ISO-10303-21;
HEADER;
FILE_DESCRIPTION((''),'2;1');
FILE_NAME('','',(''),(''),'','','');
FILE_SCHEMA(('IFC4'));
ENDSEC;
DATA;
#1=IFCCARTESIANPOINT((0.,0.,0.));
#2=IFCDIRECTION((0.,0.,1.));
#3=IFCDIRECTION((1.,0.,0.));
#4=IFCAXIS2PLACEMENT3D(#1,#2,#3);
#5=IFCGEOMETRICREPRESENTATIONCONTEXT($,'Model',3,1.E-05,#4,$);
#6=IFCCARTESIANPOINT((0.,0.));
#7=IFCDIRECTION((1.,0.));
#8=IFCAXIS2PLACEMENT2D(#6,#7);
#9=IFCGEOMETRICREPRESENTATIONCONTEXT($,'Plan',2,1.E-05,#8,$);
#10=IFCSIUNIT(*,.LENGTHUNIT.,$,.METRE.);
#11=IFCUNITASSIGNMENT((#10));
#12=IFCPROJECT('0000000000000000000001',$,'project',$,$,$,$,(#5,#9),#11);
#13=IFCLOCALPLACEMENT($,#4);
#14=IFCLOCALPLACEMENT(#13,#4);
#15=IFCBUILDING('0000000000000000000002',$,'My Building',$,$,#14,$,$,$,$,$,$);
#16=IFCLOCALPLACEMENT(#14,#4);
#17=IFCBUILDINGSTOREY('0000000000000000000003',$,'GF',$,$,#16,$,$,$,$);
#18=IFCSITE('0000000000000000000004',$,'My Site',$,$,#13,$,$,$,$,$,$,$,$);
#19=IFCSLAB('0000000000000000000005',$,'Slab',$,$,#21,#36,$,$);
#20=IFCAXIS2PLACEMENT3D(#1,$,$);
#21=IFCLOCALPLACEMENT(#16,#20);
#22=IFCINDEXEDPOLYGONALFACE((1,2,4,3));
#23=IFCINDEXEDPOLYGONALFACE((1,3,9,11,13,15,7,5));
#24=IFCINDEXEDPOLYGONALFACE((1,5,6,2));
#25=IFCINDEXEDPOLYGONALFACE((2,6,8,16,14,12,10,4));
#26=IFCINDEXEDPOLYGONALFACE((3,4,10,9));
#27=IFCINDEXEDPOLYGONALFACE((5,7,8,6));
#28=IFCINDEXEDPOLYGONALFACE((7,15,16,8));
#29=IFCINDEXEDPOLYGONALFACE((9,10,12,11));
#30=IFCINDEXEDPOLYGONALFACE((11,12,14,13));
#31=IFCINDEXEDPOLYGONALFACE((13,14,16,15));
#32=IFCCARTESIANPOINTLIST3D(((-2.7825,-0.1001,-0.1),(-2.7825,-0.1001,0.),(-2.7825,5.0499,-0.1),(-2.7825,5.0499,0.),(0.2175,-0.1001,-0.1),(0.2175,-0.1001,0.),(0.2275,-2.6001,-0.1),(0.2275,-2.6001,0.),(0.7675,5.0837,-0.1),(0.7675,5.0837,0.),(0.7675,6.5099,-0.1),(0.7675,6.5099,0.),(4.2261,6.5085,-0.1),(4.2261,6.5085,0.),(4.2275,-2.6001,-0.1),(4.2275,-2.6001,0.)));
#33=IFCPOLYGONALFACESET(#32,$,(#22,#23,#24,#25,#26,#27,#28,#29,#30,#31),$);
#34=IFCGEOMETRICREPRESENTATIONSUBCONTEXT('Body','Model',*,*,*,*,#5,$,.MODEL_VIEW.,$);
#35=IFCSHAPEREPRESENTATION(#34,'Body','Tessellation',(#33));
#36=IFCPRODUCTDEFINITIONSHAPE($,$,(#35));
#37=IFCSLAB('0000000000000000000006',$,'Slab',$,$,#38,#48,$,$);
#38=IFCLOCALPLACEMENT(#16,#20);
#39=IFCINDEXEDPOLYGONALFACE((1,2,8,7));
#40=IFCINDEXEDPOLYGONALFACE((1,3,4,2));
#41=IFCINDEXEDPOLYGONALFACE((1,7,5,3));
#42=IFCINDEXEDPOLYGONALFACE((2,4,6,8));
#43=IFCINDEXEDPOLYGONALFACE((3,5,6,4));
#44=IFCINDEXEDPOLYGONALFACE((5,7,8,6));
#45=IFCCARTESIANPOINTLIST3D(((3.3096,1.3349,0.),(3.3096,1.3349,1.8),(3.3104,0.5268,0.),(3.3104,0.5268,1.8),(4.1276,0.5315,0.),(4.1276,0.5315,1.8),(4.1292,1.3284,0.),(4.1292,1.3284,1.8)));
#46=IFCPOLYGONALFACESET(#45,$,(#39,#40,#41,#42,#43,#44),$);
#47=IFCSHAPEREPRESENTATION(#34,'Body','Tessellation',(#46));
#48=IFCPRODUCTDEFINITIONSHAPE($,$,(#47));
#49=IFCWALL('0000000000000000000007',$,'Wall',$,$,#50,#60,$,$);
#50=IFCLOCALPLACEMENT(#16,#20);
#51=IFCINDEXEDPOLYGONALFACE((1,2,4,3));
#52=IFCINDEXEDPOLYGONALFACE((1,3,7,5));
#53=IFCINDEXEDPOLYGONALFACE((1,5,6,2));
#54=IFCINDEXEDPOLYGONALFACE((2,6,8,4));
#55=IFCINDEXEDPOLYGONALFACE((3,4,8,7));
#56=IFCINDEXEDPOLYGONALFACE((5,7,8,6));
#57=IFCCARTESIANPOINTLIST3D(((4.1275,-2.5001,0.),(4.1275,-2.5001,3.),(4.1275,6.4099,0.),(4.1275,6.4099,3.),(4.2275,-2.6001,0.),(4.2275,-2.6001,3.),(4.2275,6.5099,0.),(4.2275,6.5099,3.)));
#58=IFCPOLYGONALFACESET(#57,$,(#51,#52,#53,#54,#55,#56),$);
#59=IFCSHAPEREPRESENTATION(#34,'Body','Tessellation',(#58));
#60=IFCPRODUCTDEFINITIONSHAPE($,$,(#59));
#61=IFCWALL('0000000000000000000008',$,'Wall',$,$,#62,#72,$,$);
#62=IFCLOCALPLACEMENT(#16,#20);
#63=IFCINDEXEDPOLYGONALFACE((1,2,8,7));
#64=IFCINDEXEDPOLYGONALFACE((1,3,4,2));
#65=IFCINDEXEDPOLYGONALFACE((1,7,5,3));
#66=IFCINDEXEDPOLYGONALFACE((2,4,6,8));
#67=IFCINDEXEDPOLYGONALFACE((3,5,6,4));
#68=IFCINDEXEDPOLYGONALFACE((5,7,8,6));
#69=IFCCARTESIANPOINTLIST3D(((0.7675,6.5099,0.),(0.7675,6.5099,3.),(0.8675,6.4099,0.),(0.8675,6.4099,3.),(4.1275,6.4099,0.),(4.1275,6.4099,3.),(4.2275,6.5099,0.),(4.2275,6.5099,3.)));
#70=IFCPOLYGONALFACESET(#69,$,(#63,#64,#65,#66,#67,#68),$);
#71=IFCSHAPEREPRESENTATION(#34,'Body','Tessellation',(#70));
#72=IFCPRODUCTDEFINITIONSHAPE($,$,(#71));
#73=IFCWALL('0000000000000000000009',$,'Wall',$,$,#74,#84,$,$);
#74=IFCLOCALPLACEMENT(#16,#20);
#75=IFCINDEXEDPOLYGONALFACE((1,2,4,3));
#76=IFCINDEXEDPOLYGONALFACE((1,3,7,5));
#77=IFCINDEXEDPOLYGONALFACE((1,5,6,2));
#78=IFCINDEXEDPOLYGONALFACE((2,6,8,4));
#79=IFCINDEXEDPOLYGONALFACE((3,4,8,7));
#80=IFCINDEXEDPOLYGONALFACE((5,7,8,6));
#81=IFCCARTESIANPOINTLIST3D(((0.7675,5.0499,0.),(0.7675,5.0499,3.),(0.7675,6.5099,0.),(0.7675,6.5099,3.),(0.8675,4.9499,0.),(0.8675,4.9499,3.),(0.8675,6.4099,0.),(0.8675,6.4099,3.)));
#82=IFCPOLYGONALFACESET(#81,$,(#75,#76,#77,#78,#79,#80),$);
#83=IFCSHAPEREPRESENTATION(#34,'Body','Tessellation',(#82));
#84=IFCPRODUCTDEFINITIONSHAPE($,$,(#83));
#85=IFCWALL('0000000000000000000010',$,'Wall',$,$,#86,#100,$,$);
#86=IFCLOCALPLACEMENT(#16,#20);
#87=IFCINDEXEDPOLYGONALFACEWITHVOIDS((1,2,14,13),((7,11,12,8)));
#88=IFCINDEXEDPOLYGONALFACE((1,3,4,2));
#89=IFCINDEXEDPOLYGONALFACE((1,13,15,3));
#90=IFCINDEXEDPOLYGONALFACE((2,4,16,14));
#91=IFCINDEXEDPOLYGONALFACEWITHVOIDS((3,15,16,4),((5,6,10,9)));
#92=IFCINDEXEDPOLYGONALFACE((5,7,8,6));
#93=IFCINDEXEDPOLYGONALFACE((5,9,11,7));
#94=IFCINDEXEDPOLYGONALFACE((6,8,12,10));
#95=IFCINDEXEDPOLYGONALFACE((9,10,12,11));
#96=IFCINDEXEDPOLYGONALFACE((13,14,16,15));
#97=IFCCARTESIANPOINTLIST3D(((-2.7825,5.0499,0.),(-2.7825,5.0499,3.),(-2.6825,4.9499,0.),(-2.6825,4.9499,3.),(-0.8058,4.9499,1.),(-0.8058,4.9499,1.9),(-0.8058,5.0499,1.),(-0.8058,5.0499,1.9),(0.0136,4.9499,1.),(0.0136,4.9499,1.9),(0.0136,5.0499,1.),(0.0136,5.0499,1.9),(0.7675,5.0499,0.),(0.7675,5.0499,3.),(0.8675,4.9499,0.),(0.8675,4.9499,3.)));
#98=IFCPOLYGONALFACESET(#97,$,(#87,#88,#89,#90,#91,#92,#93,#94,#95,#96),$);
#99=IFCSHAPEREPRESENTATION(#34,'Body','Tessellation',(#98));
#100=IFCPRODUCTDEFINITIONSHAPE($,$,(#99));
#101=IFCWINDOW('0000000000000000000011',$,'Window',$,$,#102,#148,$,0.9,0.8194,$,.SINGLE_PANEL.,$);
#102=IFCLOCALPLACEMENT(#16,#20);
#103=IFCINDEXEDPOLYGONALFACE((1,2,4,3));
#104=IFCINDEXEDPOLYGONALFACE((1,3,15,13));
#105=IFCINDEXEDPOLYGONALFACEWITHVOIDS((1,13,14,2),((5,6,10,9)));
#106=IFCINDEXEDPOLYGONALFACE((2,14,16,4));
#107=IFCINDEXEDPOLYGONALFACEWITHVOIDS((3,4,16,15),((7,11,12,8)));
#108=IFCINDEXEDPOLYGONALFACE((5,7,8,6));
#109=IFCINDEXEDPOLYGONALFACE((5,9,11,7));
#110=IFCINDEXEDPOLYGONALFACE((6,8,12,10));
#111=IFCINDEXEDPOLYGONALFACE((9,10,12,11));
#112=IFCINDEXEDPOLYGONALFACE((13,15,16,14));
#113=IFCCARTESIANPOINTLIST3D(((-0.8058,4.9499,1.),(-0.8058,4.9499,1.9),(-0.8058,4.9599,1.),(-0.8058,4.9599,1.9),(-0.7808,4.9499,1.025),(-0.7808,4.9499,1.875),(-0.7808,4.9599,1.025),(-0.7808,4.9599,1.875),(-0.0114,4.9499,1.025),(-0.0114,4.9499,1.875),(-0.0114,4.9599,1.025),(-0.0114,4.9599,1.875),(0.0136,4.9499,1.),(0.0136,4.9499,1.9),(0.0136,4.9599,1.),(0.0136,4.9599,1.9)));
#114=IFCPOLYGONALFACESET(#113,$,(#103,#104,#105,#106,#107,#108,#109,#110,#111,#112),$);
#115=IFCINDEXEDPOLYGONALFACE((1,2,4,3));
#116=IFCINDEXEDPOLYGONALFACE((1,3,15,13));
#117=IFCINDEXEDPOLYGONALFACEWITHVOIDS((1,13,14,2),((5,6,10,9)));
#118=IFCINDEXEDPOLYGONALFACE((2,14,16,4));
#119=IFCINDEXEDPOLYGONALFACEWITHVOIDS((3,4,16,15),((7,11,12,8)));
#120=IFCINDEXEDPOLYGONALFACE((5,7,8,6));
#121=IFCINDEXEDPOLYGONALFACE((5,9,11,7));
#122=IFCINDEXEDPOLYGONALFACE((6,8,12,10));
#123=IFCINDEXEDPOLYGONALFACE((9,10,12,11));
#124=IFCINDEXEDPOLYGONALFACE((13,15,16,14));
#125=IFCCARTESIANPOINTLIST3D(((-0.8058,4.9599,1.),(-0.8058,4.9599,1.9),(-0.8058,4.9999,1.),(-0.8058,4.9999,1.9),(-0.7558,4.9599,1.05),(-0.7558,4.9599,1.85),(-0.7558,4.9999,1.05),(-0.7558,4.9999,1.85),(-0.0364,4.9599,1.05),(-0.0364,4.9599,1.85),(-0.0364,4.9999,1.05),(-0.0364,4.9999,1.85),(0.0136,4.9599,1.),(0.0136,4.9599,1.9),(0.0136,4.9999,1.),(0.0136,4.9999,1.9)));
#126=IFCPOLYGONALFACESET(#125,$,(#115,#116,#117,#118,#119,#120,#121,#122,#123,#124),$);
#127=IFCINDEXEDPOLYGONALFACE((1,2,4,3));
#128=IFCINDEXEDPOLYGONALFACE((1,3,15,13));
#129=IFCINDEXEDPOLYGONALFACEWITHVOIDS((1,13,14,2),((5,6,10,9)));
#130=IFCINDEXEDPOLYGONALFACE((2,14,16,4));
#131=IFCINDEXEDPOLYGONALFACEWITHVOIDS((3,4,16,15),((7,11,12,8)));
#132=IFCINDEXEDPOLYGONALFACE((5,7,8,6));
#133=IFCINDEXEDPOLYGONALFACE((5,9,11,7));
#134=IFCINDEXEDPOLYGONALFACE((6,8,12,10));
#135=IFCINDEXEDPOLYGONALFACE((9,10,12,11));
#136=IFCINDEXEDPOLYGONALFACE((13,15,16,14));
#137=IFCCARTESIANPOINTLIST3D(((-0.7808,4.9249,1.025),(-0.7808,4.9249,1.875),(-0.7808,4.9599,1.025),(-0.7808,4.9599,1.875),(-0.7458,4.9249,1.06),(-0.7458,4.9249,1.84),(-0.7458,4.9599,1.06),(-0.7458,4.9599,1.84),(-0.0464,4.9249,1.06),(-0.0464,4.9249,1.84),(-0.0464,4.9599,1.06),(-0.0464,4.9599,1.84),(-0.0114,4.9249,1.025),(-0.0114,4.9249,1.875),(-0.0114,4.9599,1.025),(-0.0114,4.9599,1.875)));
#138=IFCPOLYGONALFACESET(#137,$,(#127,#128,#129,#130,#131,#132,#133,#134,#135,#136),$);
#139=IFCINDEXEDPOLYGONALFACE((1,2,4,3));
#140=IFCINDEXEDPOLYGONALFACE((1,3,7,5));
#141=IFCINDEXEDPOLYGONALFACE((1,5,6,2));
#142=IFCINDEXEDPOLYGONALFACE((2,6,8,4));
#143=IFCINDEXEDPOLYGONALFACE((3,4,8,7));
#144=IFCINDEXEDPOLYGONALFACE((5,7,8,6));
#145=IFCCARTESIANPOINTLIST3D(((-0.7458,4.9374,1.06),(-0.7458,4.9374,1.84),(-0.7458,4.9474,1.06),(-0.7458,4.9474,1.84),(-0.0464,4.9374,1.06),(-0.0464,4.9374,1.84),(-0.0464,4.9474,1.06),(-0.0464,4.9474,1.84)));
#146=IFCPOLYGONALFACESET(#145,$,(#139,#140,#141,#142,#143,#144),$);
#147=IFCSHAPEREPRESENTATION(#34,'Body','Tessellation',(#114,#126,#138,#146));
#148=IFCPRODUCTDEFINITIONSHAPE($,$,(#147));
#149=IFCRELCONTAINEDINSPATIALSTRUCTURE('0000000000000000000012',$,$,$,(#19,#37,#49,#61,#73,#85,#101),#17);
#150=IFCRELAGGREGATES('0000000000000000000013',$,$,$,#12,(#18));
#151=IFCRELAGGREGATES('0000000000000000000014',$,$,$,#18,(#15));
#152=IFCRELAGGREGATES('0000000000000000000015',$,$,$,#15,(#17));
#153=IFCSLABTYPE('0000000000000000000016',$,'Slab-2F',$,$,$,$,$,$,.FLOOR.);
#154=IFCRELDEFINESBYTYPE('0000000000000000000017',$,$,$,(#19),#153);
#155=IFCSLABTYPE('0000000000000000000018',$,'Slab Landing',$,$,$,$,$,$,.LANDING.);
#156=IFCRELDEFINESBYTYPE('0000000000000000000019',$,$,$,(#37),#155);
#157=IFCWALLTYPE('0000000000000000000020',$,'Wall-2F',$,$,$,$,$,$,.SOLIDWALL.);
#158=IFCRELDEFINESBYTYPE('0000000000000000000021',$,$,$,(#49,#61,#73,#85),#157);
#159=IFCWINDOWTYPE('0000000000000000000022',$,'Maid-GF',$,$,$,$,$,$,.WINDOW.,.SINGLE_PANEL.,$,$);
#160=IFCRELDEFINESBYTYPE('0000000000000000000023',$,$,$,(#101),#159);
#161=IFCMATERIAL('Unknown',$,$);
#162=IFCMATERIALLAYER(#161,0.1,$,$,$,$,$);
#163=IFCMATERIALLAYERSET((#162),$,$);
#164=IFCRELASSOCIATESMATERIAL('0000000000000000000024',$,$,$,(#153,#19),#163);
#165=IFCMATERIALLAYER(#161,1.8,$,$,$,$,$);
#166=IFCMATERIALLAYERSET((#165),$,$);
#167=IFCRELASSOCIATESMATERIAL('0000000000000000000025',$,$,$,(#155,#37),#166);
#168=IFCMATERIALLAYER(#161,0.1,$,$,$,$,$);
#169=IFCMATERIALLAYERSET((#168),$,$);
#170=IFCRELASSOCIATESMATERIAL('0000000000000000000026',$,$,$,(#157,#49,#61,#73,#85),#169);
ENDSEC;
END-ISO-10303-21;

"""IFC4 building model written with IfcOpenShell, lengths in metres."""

from ifc_helpers import new_model, entity, si_unit, frame, origin_with_axes, origin_2d_with_axis, place, context, subcontext, project, spatial, line, indexed_curve, outline, extrude, shape, source, transform, mapped, material, layer, layer_set, layer_usage, type_object, type_shapes, element, fill, save


model = new_model("IFC4")

# Units and contexts
model_context = context("Model", 3, precision=1e-05, world=origin_with_axes())
plan_context = context("Plan", 2, precision=1e-05, world=origin_2d_with_axis())
body_context_1 = subcontext(model_context, "Body", "Model", "MODEL_VIEW")
body_context_2 = subcontext(plan_context, "Body", "Plan", "PLAN_VIEW")
ifc_project = project(units=[si_unit("LENGTHUNIT", "METRE")], contexts=[model_context, plan_context])

# Site, building, storey
site_placement = place(None, origin_with_axes())
site = spatial("IfcSite", under=ifc_project, at=site_placement, Name="My Site")
building_placement = place(site_placement, origin_with_axes())
building = spatial("IfcBuilding", under=site, at=building_placement, Name="My Building")
storey_placement = place(building_placement, origin_with_axes())
storey = spatial("IfcBuildingStorey", under=building, at=storey_placement, Name="GF")

# Slabs
ifc_material_1 = material(Name="Unknown")
ifc_layer_1 = layer(ifc_material_1, 0.1)
ifc_layer_set_1 = layer_set([ifc_layer_1])
ifc_layer_usage_1 = layer_usage(ifc_layer_set_1, "AXIS3", "POSITIVE", -0.1)
slab_type_1 = type_object("IfcSlabType", Name="Slab-2F", PredefinedType="FLOOR", material=ifc_layer_set_1)
slab_1_placement = place(storey_placement, frame((4.2275, -2.6001, 0.0), z_axis=(0.0, 0.0, 1.0), x_axis=(1.0, 0.0, 0.0)))
element("IfcSlab", 1, at=slab_1_placement, inside=storey, type_object=slab_type_1, material=ifc_layer_usage_1, Name="Slab", context=body_context_1, shape_type="SweptSolid", body=[
    extrude(outline(indexed_curve([(0.0, 0.0), (-0.0014, 9.1086), (-3.46, 9.11), (-3.46, 7.6838), (-7.01, 7.65), (-7.01, 2.5), (-4.01, 2.5), (-4.0, 0.0), (0.0, 0.0)])), frame((0.0, 0.0, -0.1), z_axis=(0.0, 0.0, 1.0), x_axis=(1.0, 0.0, 0.0)), (0.0, 0.0, 1.0), 0.1),
])
ifc_layer_2 = layer(ifc_material_1, 1.8)
ifc_layer_set_2 = layer_set([ifc_layer_2])
ifc_layer_usage_2 = layer_usage(ifc_layer_set_2, "AXIS3", "POSITIVE", -0.1)
slab_type_2 = type_object("IfcSlabType", Name="Slab Landing", PredefinedType="LANDING", material=ifc_layer_set_2)
slab_2_placement = place(storey_placement, frame((3.3096, 1.3349, 0.1), z_axis=(0.0, 0.0, 1.0), x_axis=(1.0, 0.0, 0.0)))
element("IfcSlab", 2, at=slab_2_placement, inside=storey, type_object=slab_type_2, material=ifc_layer_usage_2, Name="Slab", context=body_context_1, shape_type="SweptSolid", body=[
    extrude(outline(indexed_curve([(0.0, 0.0), (0.0008, -0.8081), (0.818, -0.8034), (0.8196, -0.0065), (-0.0002, 0.0), (0.0, 0.0)])), frame((0.0, 0.0, -0.1), z_axis=(0.0, 0.0, 1.0), x_axis=(1.0, 0.0, 0.0)), (0.0, 0.0, 1.0), 1.8),
])

# Shared definitions
ifc_layer_3 = layer(ifc_material_1, 0.1)
ifc_layer_set_3 = layer_set([ifc_layer_3])
wall_type = type_object("IfcWallType", Name="Wall-2F", PredefinedType="SOLIDWALL", material=ifc_layer_set_3)

# Walls
ifc_layer_usage_3 = layer_usage(ifc_layer_set_3, "AXIS2", "POSITIVE", 0.0)
wall_1_placement = place(storey_placement, frame((4.2275, -2.6001, 0.0), z_axis=(0.0, 0.0, 1.0), x_axis=(0.0, 1.0, 0.0)))
element("IfcWall", 3, at=wall_1_placement, inside=storey, type_object=wall_type, material=ifc_layer_usage_3, Name="Wall", context=body_context_1, shape_type="SweptSolid", body=[
    extrude(outline(indexed_curve([(0.0, 0.0), (0.1, 0.1), (9.01, 0.1), (9.11, 0.0)], segments=[line(1, 2, 3, 4, 1)])), origin_with_axes(), (0.0, 0.0, 1.0), 3.0),
])
ifc_layer_usage_4 = layer_usage(ifc_layer_set_3, "AXIS2", "POSITIVE", 0.0)
wall_2_placement = place(storey_placement, frame((4.2275, 6.5099, 0.0), z_axis=(0.0, 0.0, 1.0), x_axis=(-1.0, 0.0, 0.0)))
element("IfcWall", 4, at=wall_2_placement, inside=storey, type_object=wall_type, material=ifc_layer_usage_4, Name="Wall", context=body_context_1, shape_type="SweptSolid", body=[
    extrude(outline(indexed_curve([(0.0, 0.0), (0.1, 0.1), (3.36, 0.1), (3.46, 0.0)], segments=[line(1, 2, 3, 4, 1)])), origin_with_axes(), (0.0, 0.0, 1.0), 3.0),
])
ifc_layer_usage_5 = layer_usage(ifc_layer_set_3, "AXIS2", "POSITIVE", 0.0)
wall_3_placement = place(storey_placement, frame((0.7675, 6.5099, 0.0), z_axis=(0.0, 0.0, 1.0), x_axis=(0.0, -1.0, 0.0)))
element("IfcWall", 5, at=wall_3_placement, inside=storey, type_object=wall_type, material=ifc_layer_usage_5, Name="Wall", context=body_context_1, shape_type="SweptSolid", body=[
    extrude(outline(indexed_curve([(0.0, 0.0), (0.1, 0.1), (1.56, 0.1), (1.46, 0.0)], segments=[line(1, 2, 3, 4, 1)])), origin_with_axes(), (0.0, 0.0, 1.0), 3.0),
])

# Wall, opening, window
ifc_layer_usage_6 = layer_usage(ifc_layer_set_3, "AXIS2", "POSITIVE", 0.0)
wall_4_placement = place(storey_placement, frame((0.7675, 5.0499, 0.0), z_axis=(0.0, 0.0, 1.0), x_axis=(-1.0, 0.0, 0.0)))
wall_4 = element("IfcWall", 6, at=wall_4_placement, inside=storey, type_object=wall_type, material=ifc_layer_usage_6, Name="Wall", context=body_context_1, shape_type="SweptSolid", body=[
    extrude(outline(indexed_curve([(0.0, 0.0), (-0.1, 0.1), (3.45, 0.1), (3.55, 0.0)], segments=[line(1, 2, 3, 4, 1)])), origin_with_axes(), (0.0, 0.0, 1.0), 3.0),
])
shared_shape_1 = source(origin_with_axes(), body_context_1, "Body", "SweptSolid", [
    extrude(outline(indexed_curve([(0.0, 0.0), (0.8194, 0.0), (0.8194, 0.9), (0.0, 0.9)], segments=[line(1, 2, 3, 4, 1)])), frame((0.0, -0.6, 0.0), z_axis=(0.0, -1.0, 0.0), x_axis=(1.0, 0.0, 0.0)), (0.0, 0.0, -1.0), 1.2),
])
opening_1_placement = place(wall_4_placement, frame((0.7539, 0.0, 1.0), z_axis=(0.0, 0.0, 1.0), x_axis=(1.0, 0.0, 0.0)))
opening_1 = element("IfcOpeningElement", 7, at=opening_1_placement, cuts=wall_4, PredefinedType="OPENING", context=body_context_1, shape_type="MappedRepresentation", body=[
    mapped(shared_shape_1, transform((0.0, 0.0, 0.0), x_axis=(1.0, 0.0, 0.0), y_axis=(0.0, 1.0, 0.0), z_axis=(0.0, 0.0, 1.0), scale=1.0)),
])
window_type_1 = type_object("IfcWindowType", Name="Maid-GF", PartitioningType="SINGLE_PANEL", PredefinedType="WINDOW")
shared_shape_2 = source(origin_with_axes(), body_context_1, "Body", "SweptSolid", [
    extrude(outline(indexed_curve([(0.0, 0.0), (0.8194, 0.0), (0.8194, 0.9), (0.0, 0.9)], segments=[line(1, 2, 3, 4, 1)]), holes=[indexed_curve([(0.025, 0.025), (0.7944, 0.025), (0.7944, 0.875), (0.025, 0.875)], segments=[line(1, 2, 3, 4, 1)])]), frame((0.0, 0.09, 0.0), z_axis=(0.0, -1.0, 0.0), x_axis=(1.0, 0.0, 0.0)), (0.0, 0.0, -1.0), 0.01),
    extrude(outline(indexed_curve([(0.0, 0.0), (0.8194, 0.0), (0.8194, 0.9), (0.0, 0.9)], segments=[line(1, 2, 3, 4, 1)]), holes=[indexed_curve([(0.05, 0.05), (0.7694, 0.05), (0.7694, 0.85), (0.05, 0.85)], segments=[line(1, 2, 3, 4, 1)])]), frame((0.0, 0.05, 0.0), z_axis=(0.0, -1.0, 0.0), x_axis=(1.0, 0.0, 0.0)), (0.0, 0.0, -1.0), 0.04),
    extrude(outline(indexed_curve([(0.0, 0.0), (0.7694, 0.0), (0.7694, 0.85), (0.0, 0.85)], segments=[line(1, 2, 3, 4, 1)]), holes=[indexed_curve([(0.035, 0.035), (0.7344, 0.035), (0.7344, 0.815), (0.035, 0.815)], segments=[line(1, 2, 3, 4, 1)])]), frame((0.025, 0.09, 0.025), z_axis=(0.0, -1.0, 0.0), x_axis=(1.0, 0.0, 0.0)), (0.0, 0.0, -1.0), 0.035),
    extrude(outline(indexed_curve([(0.035, 0.035), (0.7344, 0.035), (0.7344, 0.815), (0.035, 0.815)], segments=[line(1, 2, 3, 4, 1)])), frame((0.025, 0.1025, 0.025), z_axis=(0.0, -1.0, 0.0), x_axis=(1.0, 0.0, 0.0)), (0.0, 0.0, -1.0), 0.01),
])
shared_shape_3 = source(origin_with_axes(), body_context_2, "Body", "Curve2D", [
    entity("IfcIndexedPolyCurve", entity("IfcCartesianPointList2D", [[0.05, 0.05], [0.7694, 0.05]])),
    entity("IfcIndexedPolyCurve", entity("IfcCartesianPointList2D", [[0.0, 0.1], [0.025, 0.1], [0.025, 0.09], [0.05, 0.09], [0.05, 0.05], [0.0, 0.05]]), [entity("IfcLineIndex", [1, 2, 3, 4, 5, 6, 1])]),
    entity("IfcIndexedPolyCurve", entity("IfcCartesianPointList2D", [[0.8194, 0.1], [0.7944, 0.1], [0.7944, 0.09], [0.7694, 0.09], [0.7694, 0.05], [0.8194, 0.05]]), [entity("IfcLineIndex", [1, 2, 3, 4, 5, 6, 1])]),
    entity("IfcIndexedPolyCurve", entity("IfcCartesianPointList2D", [[0.025, 0.09], [0.06, 0.09], [0.06, 0.125], [0.025, 0.125]]), [entity("IfcLineIndex", [1, 2, 3, 4, 1])]),
    entity("IfcIndexedPolyCurve", entity("IfcCartesianPointList2D", [[0.7944, 0.09], [0.7594, 0.09], [0.7594, 0.125], [0.7944, 0.125]]), [entity("IfcLineIndex", [1, 2, 3, 4, 1])]),
    entity("IfcIndexedPolyCurve", entity("IfcCartesianPointList2D", [[0.06, 0.09], [0.7594, 0.09]])),
    entity("IfcIndexedPolyCurve", entity("IfcCartesianPointList2D", [[0.06, 0.125], [0.7594, 0.125]])),
    entity("IfcIndexedPolyCurve", entity("IfcCartesianPointList2D", [[0.06, 0.1075], [0.7594, 0.1075]])),
])
type_shapes(window_type_1, [shared_shape_2, shared_shape_3])
window_1_placement = place(opening_1_placement, frame((0.0, 0.0, 0.0), z_axis=(0.0, 0.0, 1.0), x_axis=(1.0, 0.0, 0.0)))
window_1 = element("IfcWindow", 8, at=window_1_placement, inside=storey, type_object=window_type_1, Name="Window", OverallHeight=0.9, OverallWidth=0.8194, PartitioningType="SINGLE_PANEL", shapes=[
    shape(body_context_1, "Body", "MappedRepresentation", [mapped(shared_shape_2, transform((0.0, 0.0, 0.0), x_axis=(1.0, 0.0, 0.0), y_axis=(0.0, 1.0, 0.0), z_axis=(0.0, 0.0, 1.0), scale=1.0))]),
    shape(body_context_2, "Body", "MappedRepresentation", [mapped(shared_shape_3, transform((0.0, 0.0, 0.0), x_axis=(1.0, 0.0, 0.0), y_axis=(0.0, 1.0, 0.0), z_axis=(0.0, 0.0, 1.0), scale=1.0))]),
])
fill(opening_1, window_1)

save(model, "model.ifc")
